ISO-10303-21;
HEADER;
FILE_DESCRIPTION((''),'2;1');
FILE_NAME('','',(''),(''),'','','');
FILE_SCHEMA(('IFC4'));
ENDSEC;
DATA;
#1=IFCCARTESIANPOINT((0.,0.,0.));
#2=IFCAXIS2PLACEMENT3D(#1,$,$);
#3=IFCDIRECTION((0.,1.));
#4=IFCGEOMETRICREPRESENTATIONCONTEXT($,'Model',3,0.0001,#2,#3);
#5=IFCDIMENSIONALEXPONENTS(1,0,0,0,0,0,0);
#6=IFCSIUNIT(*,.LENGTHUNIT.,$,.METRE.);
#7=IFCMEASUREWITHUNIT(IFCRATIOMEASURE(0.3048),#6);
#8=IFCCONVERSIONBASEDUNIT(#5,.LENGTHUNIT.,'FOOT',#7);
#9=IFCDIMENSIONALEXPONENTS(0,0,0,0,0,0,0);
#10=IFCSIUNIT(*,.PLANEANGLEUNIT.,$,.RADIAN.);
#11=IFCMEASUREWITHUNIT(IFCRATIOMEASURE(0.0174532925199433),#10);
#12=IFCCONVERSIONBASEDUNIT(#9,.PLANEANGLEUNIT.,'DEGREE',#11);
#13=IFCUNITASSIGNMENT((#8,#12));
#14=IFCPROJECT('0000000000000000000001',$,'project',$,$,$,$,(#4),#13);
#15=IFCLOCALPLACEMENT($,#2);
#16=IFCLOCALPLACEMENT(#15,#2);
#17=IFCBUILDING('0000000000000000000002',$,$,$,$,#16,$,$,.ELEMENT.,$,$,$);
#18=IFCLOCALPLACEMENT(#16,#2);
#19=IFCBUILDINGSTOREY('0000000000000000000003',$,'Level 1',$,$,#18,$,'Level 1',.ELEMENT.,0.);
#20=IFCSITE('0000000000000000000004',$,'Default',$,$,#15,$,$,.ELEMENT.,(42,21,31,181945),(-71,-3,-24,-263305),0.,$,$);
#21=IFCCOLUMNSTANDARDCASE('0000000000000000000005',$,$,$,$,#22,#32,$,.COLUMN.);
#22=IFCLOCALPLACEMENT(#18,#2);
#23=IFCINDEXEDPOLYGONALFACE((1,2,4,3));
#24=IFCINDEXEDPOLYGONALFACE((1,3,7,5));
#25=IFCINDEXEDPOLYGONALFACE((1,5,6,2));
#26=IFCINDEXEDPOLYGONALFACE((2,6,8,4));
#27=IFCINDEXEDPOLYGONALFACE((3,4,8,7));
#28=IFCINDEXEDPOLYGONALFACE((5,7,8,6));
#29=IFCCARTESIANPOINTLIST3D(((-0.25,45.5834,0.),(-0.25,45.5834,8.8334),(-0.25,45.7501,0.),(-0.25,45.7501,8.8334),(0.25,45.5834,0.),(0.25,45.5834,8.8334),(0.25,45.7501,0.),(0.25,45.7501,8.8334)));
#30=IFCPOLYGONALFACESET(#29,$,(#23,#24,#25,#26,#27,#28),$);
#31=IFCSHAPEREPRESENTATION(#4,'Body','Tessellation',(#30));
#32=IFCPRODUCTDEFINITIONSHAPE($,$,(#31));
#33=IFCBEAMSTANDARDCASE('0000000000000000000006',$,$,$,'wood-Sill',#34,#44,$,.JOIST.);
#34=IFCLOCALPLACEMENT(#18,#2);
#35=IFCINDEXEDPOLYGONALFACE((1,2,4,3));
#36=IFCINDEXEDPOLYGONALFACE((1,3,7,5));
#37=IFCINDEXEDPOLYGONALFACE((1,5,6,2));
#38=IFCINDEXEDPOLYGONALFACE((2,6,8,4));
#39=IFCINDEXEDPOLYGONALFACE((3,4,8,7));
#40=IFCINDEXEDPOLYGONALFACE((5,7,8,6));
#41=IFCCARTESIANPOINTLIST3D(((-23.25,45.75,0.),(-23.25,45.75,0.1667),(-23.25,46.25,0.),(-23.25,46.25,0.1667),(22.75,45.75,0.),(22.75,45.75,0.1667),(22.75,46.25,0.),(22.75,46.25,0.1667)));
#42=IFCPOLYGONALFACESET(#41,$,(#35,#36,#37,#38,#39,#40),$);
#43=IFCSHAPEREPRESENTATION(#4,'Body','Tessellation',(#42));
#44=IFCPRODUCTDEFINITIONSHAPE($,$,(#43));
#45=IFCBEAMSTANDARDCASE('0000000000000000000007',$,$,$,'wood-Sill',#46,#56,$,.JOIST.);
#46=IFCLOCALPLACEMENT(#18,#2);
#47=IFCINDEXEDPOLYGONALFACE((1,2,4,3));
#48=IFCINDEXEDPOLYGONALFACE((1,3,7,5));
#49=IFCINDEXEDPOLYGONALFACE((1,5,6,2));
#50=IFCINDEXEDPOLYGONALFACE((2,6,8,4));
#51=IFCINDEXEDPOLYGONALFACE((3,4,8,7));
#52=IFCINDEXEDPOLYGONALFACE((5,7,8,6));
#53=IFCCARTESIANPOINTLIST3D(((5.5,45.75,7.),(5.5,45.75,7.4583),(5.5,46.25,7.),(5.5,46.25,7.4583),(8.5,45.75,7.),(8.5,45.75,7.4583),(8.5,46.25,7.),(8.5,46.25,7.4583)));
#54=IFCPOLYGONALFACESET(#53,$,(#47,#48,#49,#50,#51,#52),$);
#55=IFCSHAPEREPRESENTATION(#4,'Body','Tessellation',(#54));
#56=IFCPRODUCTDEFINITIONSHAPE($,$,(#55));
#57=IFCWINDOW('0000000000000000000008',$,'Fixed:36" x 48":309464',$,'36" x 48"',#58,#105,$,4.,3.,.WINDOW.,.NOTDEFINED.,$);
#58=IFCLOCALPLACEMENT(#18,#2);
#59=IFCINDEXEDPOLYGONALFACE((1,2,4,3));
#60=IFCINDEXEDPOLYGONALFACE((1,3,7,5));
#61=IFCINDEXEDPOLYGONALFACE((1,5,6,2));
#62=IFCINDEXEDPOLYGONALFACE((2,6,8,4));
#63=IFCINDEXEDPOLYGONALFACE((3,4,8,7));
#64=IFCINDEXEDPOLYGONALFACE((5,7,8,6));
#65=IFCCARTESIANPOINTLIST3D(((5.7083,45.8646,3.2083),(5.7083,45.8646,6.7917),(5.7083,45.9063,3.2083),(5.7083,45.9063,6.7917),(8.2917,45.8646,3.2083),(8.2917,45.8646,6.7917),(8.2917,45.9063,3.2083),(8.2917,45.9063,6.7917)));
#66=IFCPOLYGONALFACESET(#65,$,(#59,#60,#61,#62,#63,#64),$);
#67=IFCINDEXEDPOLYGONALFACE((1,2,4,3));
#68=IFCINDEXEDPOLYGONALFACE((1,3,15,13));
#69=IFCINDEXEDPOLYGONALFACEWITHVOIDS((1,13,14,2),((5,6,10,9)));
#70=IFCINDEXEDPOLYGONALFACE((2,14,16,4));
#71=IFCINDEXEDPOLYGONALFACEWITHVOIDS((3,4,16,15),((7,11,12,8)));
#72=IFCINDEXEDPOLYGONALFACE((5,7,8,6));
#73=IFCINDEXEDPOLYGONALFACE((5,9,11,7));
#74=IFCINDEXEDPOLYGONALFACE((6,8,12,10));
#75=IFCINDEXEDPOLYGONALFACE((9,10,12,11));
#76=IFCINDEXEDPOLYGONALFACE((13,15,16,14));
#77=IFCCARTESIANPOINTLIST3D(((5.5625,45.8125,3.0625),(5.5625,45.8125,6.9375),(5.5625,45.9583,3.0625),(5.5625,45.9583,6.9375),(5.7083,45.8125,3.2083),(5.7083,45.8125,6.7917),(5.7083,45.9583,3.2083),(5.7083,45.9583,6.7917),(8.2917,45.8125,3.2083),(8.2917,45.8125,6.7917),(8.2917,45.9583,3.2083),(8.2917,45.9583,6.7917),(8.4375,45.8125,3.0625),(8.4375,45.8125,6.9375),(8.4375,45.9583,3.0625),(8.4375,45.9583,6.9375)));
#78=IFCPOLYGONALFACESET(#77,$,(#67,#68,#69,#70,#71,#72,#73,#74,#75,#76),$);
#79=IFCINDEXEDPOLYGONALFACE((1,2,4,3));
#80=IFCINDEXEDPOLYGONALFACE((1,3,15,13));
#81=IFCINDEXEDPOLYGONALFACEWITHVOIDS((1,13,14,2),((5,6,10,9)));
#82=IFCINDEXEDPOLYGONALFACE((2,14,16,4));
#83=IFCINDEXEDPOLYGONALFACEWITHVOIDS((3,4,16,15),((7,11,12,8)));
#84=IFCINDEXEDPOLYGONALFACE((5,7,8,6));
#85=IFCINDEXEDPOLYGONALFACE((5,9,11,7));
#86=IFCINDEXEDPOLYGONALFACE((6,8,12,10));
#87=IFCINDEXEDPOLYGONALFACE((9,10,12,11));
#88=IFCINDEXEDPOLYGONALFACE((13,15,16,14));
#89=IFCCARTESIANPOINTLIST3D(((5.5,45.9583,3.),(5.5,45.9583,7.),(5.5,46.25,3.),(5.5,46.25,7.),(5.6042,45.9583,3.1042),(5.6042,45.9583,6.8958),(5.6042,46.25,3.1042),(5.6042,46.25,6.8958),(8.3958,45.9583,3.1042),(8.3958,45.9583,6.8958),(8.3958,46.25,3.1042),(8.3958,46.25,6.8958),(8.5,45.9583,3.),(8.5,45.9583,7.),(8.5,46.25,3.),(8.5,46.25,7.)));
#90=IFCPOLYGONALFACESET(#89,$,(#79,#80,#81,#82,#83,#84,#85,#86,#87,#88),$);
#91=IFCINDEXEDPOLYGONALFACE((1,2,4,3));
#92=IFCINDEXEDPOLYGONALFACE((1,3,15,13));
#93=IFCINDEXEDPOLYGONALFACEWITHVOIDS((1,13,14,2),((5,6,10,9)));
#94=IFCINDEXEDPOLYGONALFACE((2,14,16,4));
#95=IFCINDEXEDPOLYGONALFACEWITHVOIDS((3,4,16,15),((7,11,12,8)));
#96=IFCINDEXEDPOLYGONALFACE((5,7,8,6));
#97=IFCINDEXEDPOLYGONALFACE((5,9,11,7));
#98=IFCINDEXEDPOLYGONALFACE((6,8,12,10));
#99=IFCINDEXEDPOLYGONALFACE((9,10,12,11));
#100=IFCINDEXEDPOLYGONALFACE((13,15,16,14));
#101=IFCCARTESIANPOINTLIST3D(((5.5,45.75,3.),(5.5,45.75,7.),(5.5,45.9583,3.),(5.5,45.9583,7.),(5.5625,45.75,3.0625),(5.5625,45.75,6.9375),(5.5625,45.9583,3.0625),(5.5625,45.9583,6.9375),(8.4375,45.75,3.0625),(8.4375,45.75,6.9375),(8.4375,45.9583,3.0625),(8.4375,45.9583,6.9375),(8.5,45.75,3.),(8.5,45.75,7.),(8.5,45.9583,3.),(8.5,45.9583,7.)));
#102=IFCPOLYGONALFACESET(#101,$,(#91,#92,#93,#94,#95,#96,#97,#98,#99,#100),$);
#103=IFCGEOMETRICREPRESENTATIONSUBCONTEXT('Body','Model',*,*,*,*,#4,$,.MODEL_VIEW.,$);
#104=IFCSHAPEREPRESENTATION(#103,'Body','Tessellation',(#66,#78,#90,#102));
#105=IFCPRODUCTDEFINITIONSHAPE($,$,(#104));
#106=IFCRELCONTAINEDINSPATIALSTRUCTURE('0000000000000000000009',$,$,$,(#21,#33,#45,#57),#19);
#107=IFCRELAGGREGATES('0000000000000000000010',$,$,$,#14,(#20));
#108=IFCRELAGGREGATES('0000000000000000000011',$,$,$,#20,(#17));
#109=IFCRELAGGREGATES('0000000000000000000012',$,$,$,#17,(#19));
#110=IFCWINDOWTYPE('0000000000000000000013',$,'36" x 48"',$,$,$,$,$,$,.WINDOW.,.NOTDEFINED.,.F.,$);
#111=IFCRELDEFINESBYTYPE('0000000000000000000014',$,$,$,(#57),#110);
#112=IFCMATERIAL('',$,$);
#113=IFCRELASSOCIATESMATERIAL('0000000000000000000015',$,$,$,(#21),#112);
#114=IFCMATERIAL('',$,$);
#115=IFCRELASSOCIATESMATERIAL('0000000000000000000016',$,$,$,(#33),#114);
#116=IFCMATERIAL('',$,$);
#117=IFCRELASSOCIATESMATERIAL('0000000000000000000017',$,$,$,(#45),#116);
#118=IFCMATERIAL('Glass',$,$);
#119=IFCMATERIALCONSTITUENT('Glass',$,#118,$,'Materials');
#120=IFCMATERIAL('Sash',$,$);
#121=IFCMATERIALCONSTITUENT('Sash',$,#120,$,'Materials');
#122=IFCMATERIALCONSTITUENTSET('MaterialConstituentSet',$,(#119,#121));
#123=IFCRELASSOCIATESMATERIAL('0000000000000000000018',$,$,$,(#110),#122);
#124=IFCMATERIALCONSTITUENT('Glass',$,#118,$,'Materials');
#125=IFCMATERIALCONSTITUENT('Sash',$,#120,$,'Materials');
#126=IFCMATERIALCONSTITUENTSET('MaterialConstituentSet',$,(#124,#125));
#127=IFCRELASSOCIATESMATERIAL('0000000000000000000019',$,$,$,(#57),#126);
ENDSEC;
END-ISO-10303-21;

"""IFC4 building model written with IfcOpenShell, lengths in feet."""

from ifc_helpers import new_model, entity, si_unit, converted_unit, direction, frame, frame_2d, origin, origin_with_axes, place, context, subcontext, project, spatial, polyline, rectangle, outline, extrude, source, transform, mapped, material, constituent, constituent_set, type_object, type_shapes, element, save


model = new_model("IFC4")

# Units and contexts
model_context = context("Model", 3, precision=0.0001, world=origin(), true_north=direction((0.0, 1.0)))
body_context = subcontext(model_context, "Body", "Model", "MODEL_VIEW")
ifc_project = project(units=[converted_unit("LENGTHUNIT", "FOOT", entity("IfcRatioMeasure", 0.3048), si_unit("LENGTHUNIT", "METRE"), dimensions=[1, 0, 0, 0, 0, 0, 0]), converted_unit("PLANEANGLEUNIT", "DEGREE", entity("IfcRatioMeasure", 0.0174532925199433), si_unit("PLANEANGLEUNIT", "RADIAN"), dimensions=[0, 0, 0, 0, 0, 0, 0])], contexts=[model_context])

# Site, building, storey
site_placement = place(None, origin())
site = spatial("IfcSite", under=ifc_project, at=site_placement, Name="Default", CompositionType="ELEMENT", RefLatitude=(42, 21, 31, 181945), RefLongitude=(-71, -3, -24, -263305), RefElevation=0.0)
building_placement = place(site_placement, origin())
building = spatial("IfcBuilding", under=site, at=building_placement, CompositionType="ELEMENT")
storey_placement = place(building_placement, origin())
storey = spatial("IfcBuildingStorey", under=building, at=storey_placement, Name="Level 1", LongName="Level 1", CompositionType="ELEMENT", Elevation=0.0)

# Column
placement_1 = place(storey_placement, frame((-0.25, 46.0, 0.0)))
ifc_material_1 = material(Name="")
placement_2 = place(storey_placement, frame((0.0, -0.25, 0.0), z_axis=(0.0, 0.0, 1.0), x_axis=(0.0, 1.0, 0.0)))
column_placement = place(placement_2, frame((45.9167, 0.0, 0.0), z_axis=(0.0, 0.0, 1.0), x_axis=(1.0, 0.0, 0.0)))
element("IfcColumnStandardCase", 1, at=column_placement, inside=storey, material=ifc_material_1, PredefinedType="COLUMN", context=model_context, shape_type="SweptSolid", body=[
    extrude(rectangle(XDim=0.1667, YDim=0.5), origin(), (0.0, 0.0, 1.0), 8.8334),
])

# Beams
ifc_material_2 = material(Name="")
beam_1_placement = place(placement_1, origin_with_axes())
element("IfcBeamStandardCase", 2, at=beam_1_placement, inside=storey, material=ifc_material_2, ObjectType="wood-Sill", PredefinedType="JOIST", context=model_context, shape_type="SweptSolid", body=[
    extrude(rectangle(XDim=46.0, YDim=0.5), origin(), (0.0, 0.0, 1.0), 0.1667),
])
ifc_material_3 = material(Name="")
beam_2_placement = place(placement_1, frame((7.25, 0.0, 7.0), z_axis=(0.0, 0.0, 1.0), x_axis=(-1.0, 0.0, 0.0)))
element("IfcBeamStandardCase", 3, at=beam_2_placement, inside=storey, material=ifc_material_3, ObjectType="wood-Sill", PredefinedType="JOIST", context=model_context, shape_type="SweptSolid", body=[
    extrude(rectangle(XDim=3.0, YDim=0.5), origin(), (0.0, 0.0, 1.0), 0.4583),
])

# Window
ifc_material_4 = material(Name="Glass")
ifc_constituent_1 = constituent(ifc_material_4, Name="Glass", Category="Materials")
ifc_material_5 = material(Name="Sash")
ifc_constituent_2 = constituent(ifc_material_5, Name="Sash", Category="Materials")
ifc_constituent_set_1 = constituent_set(constituents=[ifc_constituent_1, ifc_constituent_2], Name="MaterialConstituentSet")
ifc_constituent_3 = constituent(ifc_material_4, Name="Glass", Category="Materials")
ifc_constituent_4 = constituent(ifc_material_5, Name="Sash", Category="Materials")
ifc_constituent_set_2 = constituent_set(constituents=[ifc_constituent_3, ifc_constituent_4], Name="MaterialConstituentSet")
window_type = type_object("IfcWindowType", Name="36\" x 48\"", ParameterTakesPrecedence=False, PartitioningType="NOTDEFINED", PredefinedType="WINDOW", material=ifc_constituent_set_2)
shared_shape = source(origin(), body_context, "Body", "SweptSolid", [
    extrude(rectangle(XDim=0.0417, YDim=2.5833, at=frame_2d((0.0, 0.0), x_axis=(1.0, 0.0))), frame((1.5, 0.3646, 0.2083), z_axis=(0.0, 0.0, 1.0), x_axis=(0.0, 1.0, 0.0)), (0.0, 0.0, 1.0), 3.5833),
    extrude(outline(polyline([(-1.4375, -1.9375), (1.4375, -1.9375), (1.4375, 1.9375), (-1.4375, 1.9375), (-1.4375, -1.9375)]), holes=[polyline([(-1.2917, -1.7917), (-1.2917, 1.7917), (1.2917, 1.7917), (1.2917, -1.7917), (-1.2917, -1.7917)])]), frame((1.5, 0.2917, 2.0), z_axis=(0.0, 1.0, 0.0), x_axis=(1.0, 0.0, 0.0)), (0.0, 0.0, 1.0), 0.1458),
    extrude(outline(polyline([(-1.5, -2.0), (1.5, -2.0), (1.5, 2.0), (-1.5, 2.0), (-1.5, -2.0)]), holes=[polyline([(-1.3958, -1.8958), (-1.3958, 1.8958), (1.3958, 1.8958), (1.3958, -1.8958), (-1.3958, -1.8958)])]), frame((1.5, 0.0, 2.0), z_axis=(0.0, 1.0, 0.0), x_axis=(1.0, 0.0, 0.0)), (0.0, 0.0, 1.0), 0.2917),
    extrude(outline(polyline([(-2.0, -1.5), (2.0, -1.5), (2.0, 1.5), (-2.0, 1.5), (-2.0, -1.5)]), holes=[polyline([(-1.9375, -1.4375), (-1.9375, 1.4375), (1.9375, 1.4375), (1.9375, -1.4375), (-1.9375, -1.4375)])]), frame((1.5, 0.2917, 2.0), z_axis=(0.0, 1.0, 0.0), x_axis=(0.0, 0.0, -1.0)), (0.0, 0.0, 1.0), 0.2083),
])
type_shapes(window_type, [shared_shape])
placement_3 = place(placement_1, frame((8.75, 0.25, 3.0)))
window_placement = place(placement_3, frame((0.0, 0.0, 0.0), z_axis=(0.0, 0.0, 1.0), x_axis=(-1.0, 0.0, 0.0)))
element("IfcWindow", 4, at=window_placement, inside=storey, type_object=window_type, material=ifc_constituent_set_1, Name="Fixed:36\" x 48\":309464", ObjectType="36\" x 48\"", OverallHeight=4.0, OverallWidth=3.0, PartitioningType="NOTDEFINED", PredefinedType="WINDOW", context=body_context, shape_type="MappedRepresentation", body=[
    mapped(shared_shape, transform((0.0, 0.0, 0.0), scale=1.0)),
])

save(model, "model.ifc")
